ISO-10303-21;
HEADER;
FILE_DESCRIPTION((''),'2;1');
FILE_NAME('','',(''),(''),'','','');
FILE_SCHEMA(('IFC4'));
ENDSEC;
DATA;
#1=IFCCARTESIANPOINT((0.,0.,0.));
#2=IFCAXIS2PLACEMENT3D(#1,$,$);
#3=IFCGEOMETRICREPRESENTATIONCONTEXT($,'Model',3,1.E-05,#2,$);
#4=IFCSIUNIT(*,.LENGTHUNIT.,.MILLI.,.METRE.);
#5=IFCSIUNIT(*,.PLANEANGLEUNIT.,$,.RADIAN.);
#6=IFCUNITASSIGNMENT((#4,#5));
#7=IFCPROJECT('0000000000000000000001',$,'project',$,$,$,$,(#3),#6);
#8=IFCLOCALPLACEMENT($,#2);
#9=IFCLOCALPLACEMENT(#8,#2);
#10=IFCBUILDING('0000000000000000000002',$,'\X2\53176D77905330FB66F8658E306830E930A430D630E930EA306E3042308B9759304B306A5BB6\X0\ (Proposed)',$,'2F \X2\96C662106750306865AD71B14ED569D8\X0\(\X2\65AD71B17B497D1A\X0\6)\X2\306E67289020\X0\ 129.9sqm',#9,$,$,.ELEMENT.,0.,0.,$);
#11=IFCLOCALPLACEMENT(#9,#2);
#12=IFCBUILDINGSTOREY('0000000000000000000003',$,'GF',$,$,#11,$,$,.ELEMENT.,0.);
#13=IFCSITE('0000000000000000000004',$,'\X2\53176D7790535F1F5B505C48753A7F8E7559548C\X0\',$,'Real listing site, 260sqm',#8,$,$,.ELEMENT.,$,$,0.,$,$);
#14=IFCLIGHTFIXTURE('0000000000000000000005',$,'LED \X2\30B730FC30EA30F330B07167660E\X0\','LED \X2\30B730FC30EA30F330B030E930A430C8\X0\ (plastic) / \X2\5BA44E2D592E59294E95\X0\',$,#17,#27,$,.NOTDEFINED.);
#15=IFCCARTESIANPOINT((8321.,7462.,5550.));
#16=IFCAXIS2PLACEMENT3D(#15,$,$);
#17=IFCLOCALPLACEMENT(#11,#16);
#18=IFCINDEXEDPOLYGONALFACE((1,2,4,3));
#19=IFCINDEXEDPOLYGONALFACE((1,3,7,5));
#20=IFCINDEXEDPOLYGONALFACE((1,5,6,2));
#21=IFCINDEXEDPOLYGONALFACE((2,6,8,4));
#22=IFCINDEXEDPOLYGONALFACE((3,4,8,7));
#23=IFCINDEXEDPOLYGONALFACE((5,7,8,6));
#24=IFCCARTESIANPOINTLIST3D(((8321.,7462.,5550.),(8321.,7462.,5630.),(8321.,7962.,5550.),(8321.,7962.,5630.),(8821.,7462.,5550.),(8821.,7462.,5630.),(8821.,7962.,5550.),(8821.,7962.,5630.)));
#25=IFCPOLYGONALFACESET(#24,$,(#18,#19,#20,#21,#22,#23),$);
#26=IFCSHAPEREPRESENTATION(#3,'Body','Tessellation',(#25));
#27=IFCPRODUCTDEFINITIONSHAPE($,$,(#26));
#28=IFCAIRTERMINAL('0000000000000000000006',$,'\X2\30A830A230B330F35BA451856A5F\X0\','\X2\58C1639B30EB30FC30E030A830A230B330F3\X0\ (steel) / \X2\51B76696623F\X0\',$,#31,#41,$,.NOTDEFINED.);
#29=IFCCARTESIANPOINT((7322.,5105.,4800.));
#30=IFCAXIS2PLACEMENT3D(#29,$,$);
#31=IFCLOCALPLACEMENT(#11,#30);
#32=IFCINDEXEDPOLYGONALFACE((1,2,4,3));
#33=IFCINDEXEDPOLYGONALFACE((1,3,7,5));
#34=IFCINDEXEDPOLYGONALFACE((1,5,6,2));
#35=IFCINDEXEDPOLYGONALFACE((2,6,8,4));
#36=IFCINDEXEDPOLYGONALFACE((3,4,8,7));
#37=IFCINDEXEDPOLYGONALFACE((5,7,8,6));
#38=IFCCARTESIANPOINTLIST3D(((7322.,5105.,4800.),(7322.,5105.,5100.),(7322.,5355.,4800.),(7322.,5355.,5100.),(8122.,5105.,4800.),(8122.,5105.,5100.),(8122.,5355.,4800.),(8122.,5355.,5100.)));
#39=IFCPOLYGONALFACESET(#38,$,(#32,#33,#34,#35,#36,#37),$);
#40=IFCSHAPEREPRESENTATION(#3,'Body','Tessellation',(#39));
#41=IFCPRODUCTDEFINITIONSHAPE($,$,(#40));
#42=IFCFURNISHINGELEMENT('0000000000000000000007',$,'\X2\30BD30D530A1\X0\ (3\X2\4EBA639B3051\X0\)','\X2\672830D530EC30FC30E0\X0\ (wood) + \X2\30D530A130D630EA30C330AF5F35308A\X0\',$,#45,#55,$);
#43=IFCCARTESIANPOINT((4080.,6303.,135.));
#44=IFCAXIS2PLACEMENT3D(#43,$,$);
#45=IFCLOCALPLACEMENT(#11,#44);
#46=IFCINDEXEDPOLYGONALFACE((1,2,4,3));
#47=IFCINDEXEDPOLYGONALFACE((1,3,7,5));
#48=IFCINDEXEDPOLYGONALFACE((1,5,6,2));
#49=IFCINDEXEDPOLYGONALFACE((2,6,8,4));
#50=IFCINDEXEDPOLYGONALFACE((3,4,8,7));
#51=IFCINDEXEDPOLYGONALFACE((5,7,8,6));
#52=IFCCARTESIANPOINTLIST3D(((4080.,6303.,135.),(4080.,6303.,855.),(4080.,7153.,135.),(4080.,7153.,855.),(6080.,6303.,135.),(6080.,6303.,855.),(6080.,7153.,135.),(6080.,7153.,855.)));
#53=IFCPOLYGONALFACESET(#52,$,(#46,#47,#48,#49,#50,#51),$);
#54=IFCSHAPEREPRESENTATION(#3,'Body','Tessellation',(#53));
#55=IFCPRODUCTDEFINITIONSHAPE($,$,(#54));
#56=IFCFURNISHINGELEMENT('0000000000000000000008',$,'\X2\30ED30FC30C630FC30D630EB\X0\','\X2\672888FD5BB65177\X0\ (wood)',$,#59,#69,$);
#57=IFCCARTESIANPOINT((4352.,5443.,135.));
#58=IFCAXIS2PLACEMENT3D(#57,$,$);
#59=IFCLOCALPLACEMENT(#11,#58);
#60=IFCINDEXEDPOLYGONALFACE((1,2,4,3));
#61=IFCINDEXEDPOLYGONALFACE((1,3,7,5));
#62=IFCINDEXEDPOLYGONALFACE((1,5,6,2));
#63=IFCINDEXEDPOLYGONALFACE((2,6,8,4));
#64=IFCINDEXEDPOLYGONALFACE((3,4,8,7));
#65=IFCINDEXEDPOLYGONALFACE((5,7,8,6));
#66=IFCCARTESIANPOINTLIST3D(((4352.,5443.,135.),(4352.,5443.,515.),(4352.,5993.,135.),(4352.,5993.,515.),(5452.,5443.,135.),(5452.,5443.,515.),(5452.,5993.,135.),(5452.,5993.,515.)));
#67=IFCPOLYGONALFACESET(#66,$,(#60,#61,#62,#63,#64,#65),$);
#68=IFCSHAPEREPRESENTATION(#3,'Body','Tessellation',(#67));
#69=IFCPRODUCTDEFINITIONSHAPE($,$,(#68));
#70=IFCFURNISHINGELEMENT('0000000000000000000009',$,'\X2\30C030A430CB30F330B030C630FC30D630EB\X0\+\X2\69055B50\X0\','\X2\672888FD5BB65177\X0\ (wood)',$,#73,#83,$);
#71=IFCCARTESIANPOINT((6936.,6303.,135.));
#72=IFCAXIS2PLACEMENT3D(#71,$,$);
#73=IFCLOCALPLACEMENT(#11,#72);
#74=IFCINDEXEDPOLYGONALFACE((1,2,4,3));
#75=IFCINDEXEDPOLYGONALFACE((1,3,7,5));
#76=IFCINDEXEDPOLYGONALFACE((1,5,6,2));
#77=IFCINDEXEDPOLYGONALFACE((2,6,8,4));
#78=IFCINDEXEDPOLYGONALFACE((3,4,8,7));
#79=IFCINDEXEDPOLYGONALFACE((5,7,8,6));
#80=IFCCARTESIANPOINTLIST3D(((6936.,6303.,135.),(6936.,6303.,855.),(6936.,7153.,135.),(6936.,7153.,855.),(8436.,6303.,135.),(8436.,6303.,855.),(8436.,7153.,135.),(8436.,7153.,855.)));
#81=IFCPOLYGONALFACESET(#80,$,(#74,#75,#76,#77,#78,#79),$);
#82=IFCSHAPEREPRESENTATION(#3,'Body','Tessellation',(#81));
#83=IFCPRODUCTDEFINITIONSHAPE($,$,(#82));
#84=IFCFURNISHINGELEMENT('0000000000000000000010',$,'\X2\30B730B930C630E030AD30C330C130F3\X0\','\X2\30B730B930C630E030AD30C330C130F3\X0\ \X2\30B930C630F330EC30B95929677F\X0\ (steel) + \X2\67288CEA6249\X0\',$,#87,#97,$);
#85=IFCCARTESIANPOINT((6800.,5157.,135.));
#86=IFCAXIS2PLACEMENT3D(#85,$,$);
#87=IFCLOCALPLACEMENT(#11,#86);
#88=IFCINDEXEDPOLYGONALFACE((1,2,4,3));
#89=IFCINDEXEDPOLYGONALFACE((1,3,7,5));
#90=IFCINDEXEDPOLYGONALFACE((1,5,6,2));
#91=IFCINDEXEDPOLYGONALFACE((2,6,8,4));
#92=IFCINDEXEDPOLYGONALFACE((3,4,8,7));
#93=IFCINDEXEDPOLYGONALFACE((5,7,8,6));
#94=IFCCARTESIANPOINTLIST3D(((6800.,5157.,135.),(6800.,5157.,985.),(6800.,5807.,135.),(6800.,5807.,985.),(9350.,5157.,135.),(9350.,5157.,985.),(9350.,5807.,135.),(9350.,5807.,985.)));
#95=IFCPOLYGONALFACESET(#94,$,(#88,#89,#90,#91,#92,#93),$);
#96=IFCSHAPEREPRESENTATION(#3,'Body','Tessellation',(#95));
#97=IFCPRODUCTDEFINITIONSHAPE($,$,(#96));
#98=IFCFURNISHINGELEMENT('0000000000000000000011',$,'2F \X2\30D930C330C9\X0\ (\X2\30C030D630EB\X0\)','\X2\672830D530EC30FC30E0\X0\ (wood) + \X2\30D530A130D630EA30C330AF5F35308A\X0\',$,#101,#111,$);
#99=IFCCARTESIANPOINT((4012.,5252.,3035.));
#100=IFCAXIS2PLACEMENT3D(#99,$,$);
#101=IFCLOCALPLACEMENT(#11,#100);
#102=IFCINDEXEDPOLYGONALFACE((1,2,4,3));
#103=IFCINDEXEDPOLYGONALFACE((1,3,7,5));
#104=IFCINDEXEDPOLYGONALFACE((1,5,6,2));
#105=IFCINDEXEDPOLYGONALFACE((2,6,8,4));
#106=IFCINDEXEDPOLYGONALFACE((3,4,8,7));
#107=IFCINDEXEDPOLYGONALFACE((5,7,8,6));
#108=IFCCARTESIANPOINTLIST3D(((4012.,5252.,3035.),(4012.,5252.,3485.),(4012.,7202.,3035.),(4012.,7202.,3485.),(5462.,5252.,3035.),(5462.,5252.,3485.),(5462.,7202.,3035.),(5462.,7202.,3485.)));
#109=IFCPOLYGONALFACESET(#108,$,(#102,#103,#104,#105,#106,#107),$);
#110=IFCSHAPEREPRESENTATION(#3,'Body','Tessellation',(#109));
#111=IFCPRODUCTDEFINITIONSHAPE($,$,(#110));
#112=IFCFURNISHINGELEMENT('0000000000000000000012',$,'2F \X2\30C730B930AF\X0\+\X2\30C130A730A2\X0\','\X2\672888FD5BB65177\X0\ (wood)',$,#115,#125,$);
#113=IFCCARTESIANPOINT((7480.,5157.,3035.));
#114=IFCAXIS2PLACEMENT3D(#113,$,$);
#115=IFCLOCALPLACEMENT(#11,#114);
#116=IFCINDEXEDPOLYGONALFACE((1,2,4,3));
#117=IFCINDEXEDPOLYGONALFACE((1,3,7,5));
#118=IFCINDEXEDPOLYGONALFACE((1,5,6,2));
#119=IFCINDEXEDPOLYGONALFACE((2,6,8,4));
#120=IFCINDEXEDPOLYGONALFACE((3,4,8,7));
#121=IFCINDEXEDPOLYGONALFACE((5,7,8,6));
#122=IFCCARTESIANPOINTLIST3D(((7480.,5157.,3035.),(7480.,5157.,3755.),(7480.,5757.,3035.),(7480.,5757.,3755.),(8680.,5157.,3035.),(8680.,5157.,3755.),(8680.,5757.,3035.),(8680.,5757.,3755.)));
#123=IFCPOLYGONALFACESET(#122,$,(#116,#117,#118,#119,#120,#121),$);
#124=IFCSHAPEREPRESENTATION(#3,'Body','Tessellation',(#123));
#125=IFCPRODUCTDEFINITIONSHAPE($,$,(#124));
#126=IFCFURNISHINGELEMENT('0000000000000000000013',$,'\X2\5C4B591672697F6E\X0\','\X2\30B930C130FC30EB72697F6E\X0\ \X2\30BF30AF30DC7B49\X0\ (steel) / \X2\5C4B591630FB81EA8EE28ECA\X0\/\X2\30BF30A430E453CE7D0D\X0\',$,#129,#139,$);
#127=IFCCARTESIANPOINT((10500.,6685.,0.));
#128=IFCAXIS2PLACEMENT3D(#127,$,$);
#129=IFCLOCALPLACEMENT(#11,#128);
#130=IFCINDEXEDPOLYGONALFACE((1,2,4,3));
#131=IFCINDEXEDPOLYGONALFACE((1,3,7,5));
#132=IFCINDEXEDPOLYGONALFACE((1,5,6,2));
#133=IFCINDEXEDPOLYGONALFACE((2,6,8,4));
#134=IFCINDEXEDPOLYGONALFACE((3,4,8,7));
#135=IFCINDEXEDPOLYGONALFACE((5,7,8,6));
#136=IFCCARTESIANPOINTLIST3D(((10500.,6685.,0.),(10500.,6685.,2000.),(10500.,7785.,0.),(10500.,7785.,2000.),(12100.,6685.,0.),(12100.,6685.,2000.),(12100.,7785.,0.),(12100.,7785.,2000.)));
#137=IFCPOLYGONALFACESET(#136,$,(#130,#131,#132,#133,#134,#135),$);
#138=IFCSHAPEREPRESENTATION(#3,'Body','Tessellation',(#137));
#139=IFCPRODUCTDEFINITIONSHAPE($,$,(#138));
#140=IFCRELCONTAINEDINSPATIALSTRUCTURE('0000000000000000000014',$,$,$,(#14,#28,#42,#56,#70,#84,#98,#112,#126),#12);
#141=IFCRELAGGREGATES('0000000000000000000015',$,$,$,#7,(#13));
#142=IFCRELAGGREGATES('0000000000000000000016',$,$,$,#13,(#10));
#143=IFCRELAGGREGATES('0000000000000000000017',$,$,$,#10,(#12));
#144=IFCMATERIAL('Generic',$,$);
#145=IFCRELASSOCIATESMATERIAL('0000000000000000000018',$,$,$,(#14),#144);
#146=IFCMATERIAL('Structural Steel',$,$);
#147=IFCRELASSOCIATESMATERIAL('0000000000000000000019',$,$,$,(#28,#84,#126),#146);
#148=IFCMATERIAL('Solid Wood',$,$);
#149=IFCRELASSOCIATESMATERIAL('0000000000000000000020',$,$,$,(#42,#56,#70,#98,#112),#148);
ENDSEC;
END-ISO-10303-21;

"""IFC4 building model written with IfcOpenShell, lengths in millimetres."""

from ifc_helpers import new_model, si_unit, frame, frame_2d, origin, place, context, project, spatial, rectangle, extrude, material, element, save


model = new_model("IFC4")

# Units and contexts
model_context = context("Model", 3, precision=1e-05, world=origin())
ifc_project = project(units=[si_unit("LENGTHUNIT", "METRE", prefix="MILLI"), si_unit("PLANEANGLEUNIT", "RADIAN")], contexts=[model_context])

# Site, building, storey
site_placement = place(None, origin())
site = spatial("IfcSite", under=ifc_project, at=site_placement, Name="北海道弟子屈町美留和", ObjectType="Real listing site, 260sqm", CompositionType="ELEMENT", RefElevation=0.0)
building_placement = place(site_placement, origin())
building = spatial("IfcBuilding", under=site, at=building_placement, Name="北海道・書斎とライブラリのある静かな家 (Proposed)", ObjectType="2F 集成材と断熱仕様(断熱等級6)の木造 129.9sqm", CompositionType="ELEMENT", ElevationOfRefHeight=0.0, ElevationOfTerrain=0.0)
storey_placement = place(building_placement, origin())
storey = spatial("IfcBuildingStorey", under=building, at=storey_placement, Name="GF", CompositionType="ELEMENT", Elevation=0.0)

# Shared definitions
ifc_material_1 = material(Name="Solid Wood")

# Shared definitions
ifc_material_2 = material(Name="Generic")

# Shared definitions
ifc_material_3 = material(Name="Structural Steel")

# Light fixture
light_fixture_placement = place(storey_placement, frame((8321.0, 7462.0, 5550.0)))
element("IfcLightFixture", 1, at=light_fixture_placement, inside=storey, material=ifc_material_2, Name="LED シーリング照明", Description="LED シーリングライト (plastic) / 室中央天井", PredefinedType="NOTDEFINED", context=model_context, shape_type="SweptSolid", body=[
    extrude(rectangle(XDim=500.0, YDim=500.0, at=frame_2d((250.0, 250.0))), frame((8321.0, 7462.0, 5550.0)), (0.0, 0.0, 1.0), 80.0),
])

# Air terminal
air_terminal_1_placement = place(storey_placement, frame((7322.0, 5105.0, 4800.0)))
element("IfcAirTerminal", 2, at=air_terminal_1_placement, inside=storey, material=ifc_material_3, Name="エアコン室内機", Description="壁掛ルームエアコン (steel) / 冷暖房", PredefinedType="NOTDEFINED", context=model_context, shape_type="SweptSolid", body=[
    extrude(rectangle(XDim=800.0, YDim=250.0, at=frame_2d((400.0, 125.0))), frame((7322.0, 5105.0, 4800.0)), (0.0, 0.0, 1.0), 300.0),
])

# Furnishing elements
furnishing_1_placement = place(storey_placement, frame((4080.0, 6303.0, 135.0)))
element("IfcFurnishingElement", 3, at=furnishing_1_placement, inside=storey, material=ifc_material_1, Name="ソファ (3人掛け)", Description="木フレーム (wood) + ファブリック張り", context=model_context, shape_type="SweptSolid", body=[
    extrude(rectangle(XDim=2000.0, YDim=850.0, at=frame_2d((1000.0, 425.0))), frame((4080.0, 6303.0, 135.0)), (0.0, 0.0, 1.0), 720.0),
])
furnishing_2_placement = place(storey_placement, frame((4352.0, 5443.0, 135.0)))
element("IfcFurnishingElement", 4, at=furnishing_2_placement, inside=storey, material=ifc_material_1, Name="ローテーブル", Description="木製家具 (wood)", context=model_context, shape_type="SweptSolid", body=[
    extrude(rectangle(XDim=1100.0, YDim=550.0, at=frame_2d((550.0, 275.0))), frame((4352.0, 5443.0, 135.0)), (0.0, 0.0, 1.0), 380.0),
])
furnishing_3_placement = place(storey_placement, frame((6936.0, 6303.0, 135.0)))
element("IfcFurnishingElement", 5, at=furnishing_3_placement, inside=storey, material=ifc_material_1, Name="ダイニングテーブル+椅子", Description="木製家具 (wood)", context=model_context, shape_type="SweptSolid", body=[
    extrude(rectangle(XDim=1500.0, YDim=850.0, at=frame_2d((750.0, 425.0))), frame((6936.0, 6303.0, 135.0)), (0.0, 0.0, 1.0), 720.0),
])
furnishing_4_placement = place(storey_placement, frame((6800.0, 5157.0, 135.0)))
element("IfcFurnishingElement", 6, at=furnishing_4_placement, inside=storey, material=ifc_material_3, Name="システムキッチン", Description="システムキッチン ステンレス天板 (steel) + 木質扉", context=model_context, shape_type="SweptSolid", body=[
    extrude(rectangle(XDim=2550.0, YDim=650.0, at=frame_2d((1275.0, 325.0))), frame((6800.0, 5157.0, 135.0)), (0.0, 0.0, 1.0), 850.0),
])
furnishing_5_placement = place(storey_placement, frame((4012.0, 5252.0, 3035.0)))
element("IfcFurnishingElement", 7, at=furnishing_5_placement, inside=storey, material=ifc_material_1, Name="2F ベッド (ダブル)", Description="木フレーム (wood) + ファブリック張り", context=model_context, shape_type="SweptSolid", body=[
    extrude(rectangle(XDim=1450.0, YDim=1950.0, at=frame_2d((725.0, 975.0))), frame((4012.0, 5252.0, 3035.0)), (0.0, 0.0, 1.0), 450.0),
])
furnishing_6_placement = place(storey_placement, frame((7480.0, 5157.0, 3035.0)))
element("IfcFurnishingElement", 8, at=furnishing_6_placement, inside=storey, material=ifc_material_1, Name="2F デスク+チェア", Description="木製家具 (wood)", context=model_context, shape_type="SweptSolid", body=[
    extrude(rectangle(XDim=1200.0, YDim=600.0, at=frame_2d((600.0, 300.0))), frame((7480.0, 5157.0, 3035.0)), (0.0, 0.0, 1.0), 720.0),
])
furnishing_7_placement = place(storey_placement, frame((10500.0, 6685.0, 0.0)))
element("IfcFurnishingElement", 9, at=furnishing_7_placement, inside=storey, material=ifc_material_3, Name="屋外物置", Description="スチール物置 タクボ等 (steel) / 屋外・自転車/タイヤ収納", context=model_context, shape_type="SweptSolid", body=[
    extrude(rectangle(XDim=1600.0, YDim=1100.0, at=frame_2d((800.0, 550.0))), frame((10500.0, 6685.0, 0.0)), (0.0, 0.0, 1.0), 2000.0),
])

save(model, "model.ifc")
